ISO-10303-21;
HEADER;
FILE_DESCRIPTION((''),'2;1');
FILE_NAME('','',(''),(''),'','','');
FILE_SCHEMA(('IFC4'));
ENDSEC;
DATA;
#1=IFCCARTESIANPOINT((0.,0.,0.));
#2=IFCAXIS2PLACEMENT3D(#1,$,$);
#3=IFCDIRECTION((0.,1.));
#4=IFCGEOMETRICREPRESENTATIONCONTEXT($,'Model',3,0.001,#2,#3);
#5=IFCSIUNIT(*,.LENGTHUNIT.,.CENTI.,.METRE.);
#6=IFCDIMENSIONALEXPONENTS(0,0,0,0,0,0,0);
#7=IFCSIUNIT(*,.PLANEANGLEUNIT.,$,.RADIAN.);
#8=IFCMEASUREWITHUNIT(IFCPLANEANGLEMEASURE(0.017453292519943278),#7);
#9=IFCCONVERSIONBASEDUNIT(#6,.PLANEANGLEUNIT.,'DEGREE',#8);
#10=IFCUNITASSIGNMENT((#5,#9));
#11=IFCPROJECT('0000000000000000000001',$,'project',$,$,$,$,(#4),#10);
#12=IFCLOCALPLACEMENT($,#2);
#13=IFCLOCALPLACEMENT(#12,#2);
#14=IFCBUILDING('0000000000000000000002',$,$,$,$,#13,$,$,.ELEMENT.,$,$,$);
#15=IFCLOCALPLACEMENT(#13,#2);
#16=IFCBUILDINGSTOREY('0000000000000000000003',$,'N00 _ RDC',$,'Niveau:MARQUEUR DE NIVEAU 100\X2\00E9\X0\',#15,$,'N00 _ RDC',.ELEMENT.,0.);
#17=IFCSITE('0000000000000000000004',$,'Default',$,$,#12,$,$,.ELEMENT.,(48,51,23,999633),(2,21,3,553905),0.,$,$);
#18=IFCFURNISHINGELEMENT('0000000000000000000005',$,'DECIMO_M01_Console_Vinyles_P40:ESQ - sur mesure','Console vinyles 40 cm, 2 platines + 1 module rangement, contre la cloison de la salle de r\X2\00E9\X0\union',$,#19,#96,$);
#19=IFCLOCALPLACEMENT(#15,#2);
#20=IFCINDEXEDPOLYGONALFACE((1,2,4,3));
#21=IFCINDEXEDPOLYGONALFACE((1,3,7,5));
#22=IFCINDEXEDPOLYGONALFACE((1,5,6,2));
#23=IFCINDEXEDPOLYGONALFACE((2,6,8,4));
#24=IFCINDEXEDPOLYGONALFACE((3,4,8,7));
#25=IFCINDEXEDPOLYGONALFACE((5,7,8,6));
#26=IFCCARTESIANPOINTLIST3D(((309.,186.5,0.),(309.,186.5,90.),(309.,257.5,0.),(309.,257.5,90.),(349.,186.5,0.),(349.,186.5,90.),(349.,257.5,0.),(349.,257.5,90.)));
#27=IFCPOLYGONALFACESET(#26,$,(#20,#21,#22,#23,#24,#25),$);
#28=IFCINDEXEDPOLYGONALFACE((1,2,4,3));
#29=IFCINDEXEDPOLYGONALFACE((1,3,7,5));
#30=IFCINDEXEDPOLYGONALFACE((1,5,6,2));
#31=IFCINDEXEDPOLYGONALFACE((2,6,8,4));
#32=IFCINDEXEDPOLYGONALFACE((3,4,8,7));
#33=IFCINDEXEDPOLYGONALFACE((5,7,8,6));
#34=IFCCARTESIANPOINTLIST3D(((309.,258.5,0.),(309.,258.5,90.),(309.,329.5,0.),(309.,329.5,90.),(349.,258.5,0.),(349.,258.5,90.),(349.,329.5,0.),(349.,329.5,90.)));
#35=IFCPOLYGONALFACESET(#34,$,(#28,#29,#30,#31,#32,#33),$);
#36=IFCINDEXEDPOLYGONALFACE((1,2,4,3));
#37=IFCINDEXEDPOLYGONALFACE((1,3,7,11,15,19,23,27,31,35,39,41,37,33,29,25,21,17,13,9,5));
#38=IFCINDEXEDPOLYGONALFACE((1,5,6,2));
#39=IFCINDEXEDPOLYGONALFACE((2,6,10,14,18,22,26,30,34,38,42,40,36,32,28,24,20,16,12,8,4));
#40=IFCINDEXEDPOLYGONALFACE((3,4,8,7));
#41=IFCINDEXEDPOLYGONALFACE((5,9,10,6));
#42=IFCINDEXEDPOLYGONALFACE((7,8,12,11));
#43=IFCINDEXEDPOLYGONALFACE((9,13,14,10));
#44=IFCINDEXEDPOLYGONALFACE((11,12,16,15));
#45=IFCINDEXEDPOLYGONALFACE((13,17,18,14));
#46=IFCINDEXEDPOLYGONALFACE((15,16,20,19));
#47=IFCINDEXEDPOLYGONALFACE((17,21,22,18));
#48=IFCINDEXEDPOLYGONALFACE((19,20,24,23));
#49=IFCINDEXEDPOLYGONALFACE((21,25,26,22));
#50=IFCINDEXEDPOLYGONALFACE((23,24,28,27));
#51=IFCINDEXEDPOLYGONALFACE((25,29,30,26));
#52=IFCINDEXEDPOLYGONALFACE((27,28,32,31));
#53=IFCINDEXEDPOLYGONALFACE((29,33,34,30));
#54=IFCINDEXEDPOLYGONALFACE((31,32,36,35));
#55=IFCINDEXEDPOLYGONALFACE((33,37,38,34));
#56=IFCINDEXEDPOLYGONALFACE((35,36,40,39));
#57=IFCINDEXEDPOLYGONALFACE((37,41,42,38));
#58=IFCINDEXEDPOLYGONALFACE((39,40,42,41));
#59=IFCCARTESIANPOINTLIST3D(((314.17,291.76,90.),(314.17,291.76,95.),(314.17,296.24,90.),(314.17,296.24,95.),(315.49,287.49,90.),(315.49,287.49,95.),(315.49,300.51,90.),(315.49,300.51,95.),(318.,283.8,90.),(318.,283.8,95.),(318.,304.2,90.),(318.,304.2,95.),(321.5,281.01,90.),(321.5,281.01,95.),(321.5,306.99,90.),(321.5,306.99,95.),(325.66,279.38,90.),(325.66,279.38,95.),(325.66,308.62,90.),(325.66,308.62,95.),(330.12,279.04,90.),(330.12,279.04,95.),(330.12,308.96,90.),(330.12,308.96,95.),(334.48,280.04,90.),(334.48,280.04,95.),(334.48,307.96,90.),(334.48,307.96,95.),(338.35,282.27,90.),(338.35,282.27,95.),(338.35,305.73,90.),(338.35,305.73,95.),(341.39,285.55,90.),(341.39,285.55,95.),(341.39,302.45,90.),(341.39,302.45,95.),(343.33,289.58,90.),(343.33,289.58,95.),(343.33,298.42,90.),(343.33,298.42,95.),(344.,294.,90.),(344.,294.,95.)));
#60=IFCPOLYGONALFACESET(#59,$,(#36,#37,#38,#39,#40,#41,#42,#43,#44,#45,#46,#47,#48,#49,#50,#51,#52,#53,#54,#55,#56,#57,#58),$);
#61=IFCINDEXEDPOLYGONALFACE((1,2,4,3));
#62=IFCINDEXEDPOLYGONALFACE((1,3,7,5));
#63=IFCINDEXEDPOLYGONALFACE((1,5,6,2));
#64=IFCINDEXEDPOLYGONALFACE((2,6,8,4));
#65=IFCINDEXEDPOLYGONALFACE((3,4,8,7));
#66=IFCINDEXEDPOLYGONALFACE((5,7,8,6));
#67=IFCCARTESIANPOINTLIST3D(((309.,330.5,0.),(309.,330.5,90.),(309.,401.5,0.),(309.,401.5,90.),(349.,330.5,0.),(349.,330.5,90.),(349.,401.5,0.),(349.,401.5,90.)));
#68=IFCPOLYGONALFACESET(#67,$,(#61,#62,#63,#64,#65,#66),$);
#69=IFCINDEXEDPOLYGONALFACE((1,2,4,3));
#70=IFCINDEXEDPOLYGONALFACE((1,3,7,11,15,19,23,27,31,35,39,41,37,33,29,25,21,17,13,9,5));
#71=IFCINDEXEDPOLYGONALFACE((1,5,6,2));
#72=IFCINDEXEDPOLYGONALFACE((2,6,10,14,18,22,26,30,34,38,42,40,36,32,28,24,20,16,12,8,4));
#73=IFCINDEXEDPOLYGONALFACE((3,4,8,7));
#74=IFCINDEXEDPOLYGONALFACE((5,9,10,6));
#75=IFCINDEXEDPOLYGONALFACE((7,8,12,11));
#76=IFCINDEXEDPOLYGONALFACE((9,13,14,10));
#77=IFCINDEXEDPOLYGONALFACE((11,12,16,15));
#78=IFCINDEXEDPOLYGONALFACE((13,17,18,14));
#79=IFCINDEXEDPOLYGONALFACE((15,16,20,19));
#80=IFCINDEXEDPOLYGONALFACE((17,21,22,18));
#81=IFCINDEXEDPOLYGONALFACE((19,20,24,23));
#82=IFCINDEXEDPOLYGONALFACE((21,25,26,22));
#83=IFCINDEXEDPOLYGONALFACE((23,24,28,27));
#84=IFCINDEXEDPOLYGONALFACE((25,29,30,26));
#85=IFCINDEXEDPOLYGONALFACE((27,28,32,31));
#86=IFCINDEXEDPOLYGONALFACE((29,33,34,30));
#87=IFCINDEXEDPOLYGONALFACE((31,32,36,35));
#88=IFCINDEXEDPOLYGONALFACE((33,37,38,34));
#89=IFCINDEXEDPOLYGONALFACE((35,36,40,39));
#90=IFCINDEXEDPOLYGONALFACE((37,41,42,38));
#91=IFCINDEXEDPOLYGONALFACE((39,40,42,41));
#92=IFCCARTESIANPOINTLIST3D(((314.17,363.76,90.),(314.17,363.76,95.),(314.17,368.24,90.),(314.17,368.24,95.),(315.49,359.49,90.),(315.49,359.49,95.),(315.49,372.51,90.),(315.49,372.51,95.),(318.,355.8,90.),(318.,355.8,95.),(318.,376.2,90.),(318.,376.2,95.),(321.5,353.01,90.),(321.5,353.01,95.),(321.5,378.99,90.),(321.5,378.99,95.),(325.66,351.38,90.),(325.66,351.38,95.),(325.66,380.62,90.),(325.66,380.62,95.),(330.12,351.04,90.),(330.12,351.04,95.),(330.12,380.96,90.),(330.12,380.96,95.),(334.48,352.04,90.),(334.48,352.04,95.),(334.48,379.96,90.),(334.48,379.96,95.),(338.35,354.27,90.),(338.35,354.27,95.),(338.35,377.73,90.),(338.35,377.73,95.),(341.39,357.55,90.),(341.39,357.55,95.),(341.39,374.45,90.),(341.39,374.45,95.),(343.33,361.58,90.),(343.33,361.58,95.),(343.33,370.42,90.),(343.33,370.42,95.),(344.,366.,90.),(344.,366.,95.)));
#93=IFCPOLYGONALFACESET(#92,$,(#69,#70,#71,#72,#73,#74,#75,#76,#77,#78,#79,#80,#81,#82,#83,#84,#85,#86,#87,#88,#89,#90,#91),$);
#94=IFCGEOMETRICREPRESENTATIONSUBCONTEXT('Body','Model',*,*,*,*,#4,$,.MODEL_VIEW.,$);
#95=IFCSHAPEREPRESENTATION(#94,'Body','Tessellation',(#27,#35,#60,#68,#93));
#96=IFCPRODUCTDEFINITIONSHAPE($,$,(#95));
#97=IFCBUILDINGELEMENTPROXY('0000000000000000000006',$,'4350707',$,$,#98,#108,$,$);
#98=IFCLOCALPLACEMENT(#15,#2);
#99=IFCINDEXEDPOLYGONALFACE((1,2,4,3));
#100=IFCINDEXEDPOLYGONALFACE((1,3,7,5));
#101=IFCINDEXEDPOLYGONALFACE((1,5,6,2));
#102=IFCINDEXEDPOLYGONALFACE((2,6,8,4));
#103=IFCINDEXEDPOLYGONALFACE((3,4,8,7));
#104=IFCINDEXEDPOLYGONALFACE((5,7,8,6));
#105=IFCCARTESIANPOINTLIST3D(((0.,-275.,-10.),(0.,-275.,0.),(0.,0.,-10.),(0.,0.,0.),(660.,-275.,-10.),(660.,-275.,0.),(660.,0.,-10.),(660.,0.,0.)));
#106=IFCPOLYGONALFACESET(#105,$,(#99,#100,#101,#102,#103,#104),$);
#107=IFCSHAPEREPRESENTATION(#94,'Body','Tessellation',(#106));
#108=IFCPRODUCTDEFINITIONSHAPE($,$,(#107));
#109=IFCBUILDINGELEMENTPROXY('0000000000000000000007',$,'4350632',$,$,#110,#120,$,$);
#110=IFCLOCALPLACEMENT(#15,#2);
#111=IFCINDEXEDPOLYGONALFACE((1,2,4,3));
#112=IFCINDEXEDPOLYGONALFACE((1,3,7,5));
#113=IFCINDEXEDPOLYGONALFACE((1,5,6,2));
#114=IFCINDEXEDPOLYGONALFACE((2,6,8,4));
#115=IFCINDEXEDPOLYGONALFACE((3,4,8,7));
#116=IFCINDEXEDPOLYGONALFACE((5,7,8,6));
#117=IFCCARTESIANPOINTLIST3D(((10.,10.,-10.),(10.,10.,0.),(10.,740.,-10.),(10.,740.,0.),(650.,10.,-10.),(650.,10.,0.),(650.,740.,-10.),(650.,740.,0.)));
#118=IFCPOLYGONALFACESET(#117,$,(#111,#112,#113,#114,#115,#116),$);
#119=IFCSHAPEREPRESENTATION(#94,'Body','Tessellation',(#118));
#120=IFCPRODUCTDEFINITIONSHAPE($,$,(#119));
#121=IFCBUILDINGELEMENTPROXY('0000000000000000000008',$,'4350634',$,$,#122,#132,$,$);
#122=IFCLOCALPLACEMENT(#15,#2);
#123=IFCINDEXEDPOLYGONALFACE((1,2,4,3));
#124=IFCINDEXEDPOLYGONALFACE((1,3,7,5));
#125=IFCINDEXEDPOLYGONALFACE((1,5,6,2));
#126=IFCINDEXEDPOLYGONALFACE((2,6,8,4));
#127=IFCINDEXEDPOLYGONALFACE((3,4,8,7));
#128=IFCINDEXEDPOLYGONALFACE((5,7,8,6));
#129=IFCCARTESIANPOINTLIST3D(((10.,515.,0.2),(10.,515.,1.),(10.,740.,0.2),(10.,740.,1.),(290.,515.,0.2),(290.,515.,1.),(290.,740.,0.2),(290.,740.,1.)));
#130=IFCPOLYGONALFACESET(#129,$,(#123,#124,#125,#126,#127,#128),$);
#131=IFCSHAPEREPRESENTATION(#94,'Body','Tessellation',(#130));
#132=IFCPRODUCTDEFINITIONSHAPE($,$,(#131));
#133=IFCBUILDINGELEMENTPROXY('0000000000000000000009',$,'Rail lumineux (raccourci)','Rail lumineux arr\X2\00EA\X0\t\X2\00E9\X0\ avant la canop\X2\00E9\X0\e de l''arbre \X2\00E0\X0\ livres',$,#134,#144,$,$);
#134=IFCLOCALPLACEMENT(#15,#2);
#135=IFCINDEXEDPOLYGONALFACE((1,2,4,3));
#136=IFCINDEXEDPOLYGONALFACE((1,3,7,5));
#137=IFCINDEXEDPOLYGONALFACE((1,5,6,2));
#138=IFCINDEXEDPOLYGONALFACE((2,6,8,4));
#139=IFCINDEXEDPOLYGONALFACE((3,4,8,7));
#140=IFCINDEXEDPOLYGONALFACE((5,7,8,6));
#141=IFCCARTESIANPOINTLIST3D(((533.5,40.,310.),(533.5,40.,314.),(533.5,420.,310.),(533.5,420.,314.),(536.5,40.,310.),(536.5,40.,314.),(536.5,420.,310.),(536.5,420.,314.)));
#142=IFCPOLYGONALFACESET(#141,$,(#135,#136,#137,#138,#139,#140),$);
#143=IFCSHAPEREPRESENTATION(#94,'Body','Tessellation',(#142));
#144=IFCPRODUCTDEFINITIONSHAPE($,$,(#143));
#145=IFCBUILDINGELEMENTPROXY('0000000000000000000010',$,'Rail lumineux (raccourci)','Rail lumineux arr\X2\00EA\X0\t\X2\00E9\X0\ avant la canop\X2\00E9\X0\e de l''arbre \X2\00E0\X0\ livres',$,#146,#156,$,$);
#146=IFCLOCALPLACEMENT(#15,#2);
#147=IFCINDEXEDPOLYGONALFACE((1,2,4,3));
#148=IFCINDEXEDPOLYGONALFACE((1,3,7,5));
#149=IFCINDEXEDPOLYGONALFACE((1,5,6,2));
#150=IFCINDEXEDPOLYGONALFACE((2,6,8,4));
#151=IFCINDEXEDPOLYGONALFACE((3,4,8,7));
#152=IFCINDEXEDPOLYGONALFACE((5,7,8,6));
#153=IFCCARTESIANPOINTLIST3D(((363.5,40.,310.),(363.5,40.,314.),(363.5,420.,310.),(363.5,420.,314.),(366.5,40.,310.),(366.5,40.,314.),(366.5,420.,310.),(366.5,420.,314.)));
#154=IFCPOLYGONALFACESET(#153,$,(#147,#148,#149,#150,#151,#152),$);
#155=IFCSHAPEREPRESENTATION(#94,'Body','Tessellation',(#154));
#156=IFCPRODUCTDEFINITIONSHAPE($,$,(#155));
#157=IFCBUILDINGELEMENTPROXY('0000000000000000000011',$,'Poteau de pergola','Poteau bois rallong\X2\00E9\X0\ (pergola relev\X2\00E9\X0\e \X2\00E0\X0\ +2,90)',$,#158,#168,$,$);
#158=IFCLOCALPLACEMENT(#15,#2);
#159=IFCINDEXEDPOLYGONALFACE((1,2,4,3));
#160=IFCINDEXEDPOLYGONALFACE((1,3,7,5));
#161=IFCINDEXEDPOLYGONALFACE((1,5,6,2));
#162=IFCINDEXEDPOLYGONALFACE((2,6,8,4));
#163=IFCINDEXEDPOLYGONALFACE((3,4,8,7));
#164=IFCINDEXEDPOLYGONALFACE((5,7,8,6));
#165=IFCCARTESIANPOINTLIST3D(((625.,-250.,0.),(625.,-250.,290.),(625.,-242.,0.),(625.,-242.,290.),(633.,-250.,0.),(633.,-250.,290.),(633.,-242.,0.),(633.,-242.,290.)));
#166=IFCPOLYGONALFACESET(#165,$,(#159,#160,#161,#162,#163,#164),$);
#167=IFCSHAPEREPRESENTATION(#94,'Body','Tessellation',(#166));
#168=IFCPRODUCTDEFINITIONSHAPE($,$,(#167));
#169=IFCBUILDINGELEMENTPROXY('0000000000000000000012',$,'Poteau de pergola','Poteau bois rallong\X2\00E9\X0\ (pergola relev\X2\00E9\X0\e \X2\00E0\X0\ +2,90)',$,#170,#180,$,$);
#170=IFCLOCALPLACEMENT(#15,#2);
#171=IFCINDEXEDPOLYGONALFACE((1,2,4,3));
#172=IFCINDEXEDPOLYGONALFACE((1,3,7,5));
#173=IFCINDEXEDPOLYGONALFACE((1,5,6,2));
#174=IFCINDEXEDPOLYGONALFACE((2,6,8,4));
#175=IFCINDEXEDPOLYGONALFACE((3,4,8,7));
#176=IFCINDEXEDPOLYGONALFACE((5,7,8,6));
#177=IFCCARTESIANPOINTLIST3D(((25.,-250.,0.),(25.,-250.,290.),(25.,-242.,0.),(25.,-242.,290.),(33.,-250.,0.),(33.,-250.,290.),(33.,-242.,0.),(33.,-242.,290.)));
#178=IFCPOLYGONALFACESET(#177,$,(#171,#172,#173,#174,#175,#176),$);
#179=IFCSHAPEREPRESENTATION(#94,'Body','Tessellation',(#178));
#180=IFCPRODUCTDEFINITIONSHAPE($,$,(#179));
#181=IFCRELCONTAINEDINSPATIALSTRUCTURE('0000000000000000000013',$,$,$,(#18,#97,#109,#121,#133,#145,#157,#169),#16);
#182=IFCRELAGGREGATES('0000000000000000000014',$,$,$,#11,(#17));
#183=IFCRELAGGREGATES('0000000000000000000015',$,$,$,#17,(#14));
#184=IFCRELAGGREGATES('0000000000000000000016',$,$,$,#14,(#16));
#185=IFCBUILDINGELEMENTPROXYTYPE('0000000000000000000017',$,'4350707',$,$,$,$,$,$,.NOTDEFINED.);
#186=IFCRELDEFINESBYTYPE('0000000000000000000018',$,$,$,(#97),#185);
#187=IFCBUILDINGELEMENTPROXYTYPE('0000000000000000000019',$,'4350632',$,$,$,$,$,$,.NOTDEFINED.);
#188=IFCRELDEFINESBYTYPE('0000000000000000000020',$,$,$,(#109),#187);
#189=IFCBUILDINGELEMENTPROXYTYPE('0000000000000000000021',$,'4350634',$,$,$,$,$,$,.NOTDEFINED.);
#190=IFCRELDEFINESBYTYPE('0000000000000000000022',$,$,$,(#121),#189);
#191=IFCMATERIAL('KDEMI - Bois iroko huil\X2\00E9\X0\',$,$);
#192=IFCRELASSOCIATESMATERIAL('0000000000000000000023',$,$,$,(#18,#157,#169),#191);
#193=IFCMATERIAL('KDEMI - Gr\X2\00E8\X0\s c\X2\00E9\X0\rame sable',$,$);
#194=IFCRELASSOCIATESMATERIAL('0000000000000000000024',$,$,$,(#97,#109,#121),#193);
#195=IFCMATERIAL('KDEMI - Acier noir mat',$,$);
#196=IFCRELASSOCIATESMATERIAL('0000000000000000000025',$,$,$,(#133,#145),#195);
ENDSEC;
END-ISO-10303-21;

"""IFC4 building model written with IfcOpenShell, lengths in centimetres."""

from ifc_helpers import new_model, entity, si_unit, converted_unit, direction, frame, frame_2d, origin, origin_with_axes, origin_2d_with_axis, place, context, subcontext, project, spatial, rectangle, circle, extrude, material, type_object, element, save


model = new_model("IFC4")

# Units and contexts
model_context = context("Model", 3, precision=0.001, world=origin(), true_north=direction((0.0, 1.0)))
body_context = subcontext(model_context, "Body", "Model", "MODEL_VIEW")
ifc_project = project(units=[si_unit("LENGTHUNIT", "METRE", prefix="CENTI"), converted_unit("PLANEANGLEUNIT", "DEGREE", entity("IfcPlaneAngleMeasure", 0.017453292519943278), si_unit("PLANEANGLEUNIT", "RADIAN"), dimensions=[0, 0, 0, 0, 0, 0, 0])], contexts=[model_context])

# Site, building, storey
site_placement = place(None, origin())
site = spatial("IfcSite", under=ifc_project, at=site_placement, Name="Default", CompositionType="ELEMENT", RefLatitude=(48, 51, 23, 999633), RefLongitude=(2, 21, 3, 553905), RefElevation=0.0)
building_placement = place(site_placement, origin())
building = spatial("IfcBuilding", under=site, at=building_placement, CompositionType="ELEMENT")
storey_placement = place(building_placement, origin())
storey = spatial("IfcBuildingStorey", under=building, at=storey_placement, Name="N00 _ RDC", ObjectType="Niveau:MARQUEUR DE NIVEAU 100é", LongName="N00 _ RDC", CompositionType="ELEMENT", Elevation=0.0)

# Shared definitions
ifc_material_1 = material(Name="KDEMI - Acier noir mat")

# Furnishing element
ifc_material_2 = material(Name="KDEMI - Bois iroko huilé")
furnishing_1_placement = place(storey_placement, origin_with_axes())
element("IfcFurnishingElement", 1, at=furnishing_1_placement, inside=storey, material=ifc_material_2, Name="DECIMO_M01_Console_Vinyles_P40:ESQ - sur mesure", Description="Console vinyles 40 cm, 2 platines + 1 module rangement, contre la cloison de la salle de réunion", context=body_context, shape_type="SweptSolid", body=[
    extrude(rectangle(XDim=40.0, YDim=71.0, at=frame_2d((329.0, 222.0))), origin(), (0.0, 0.0, 1.0), 90.0),
    extrude(rectangle(XDim=40.0, YDim=71.0, at=frame_2d((329.0, 294.0))), origin(), (0.0, 0.0, 1.0), 90.0),
    extrude(circle(Radius=15.0, at=frame_2d((329.0, 294.0))), frame((0.0, 0.0, 90.0)), (0.0, 0.0, 1.0), 5.0),
    extrude(rectangle(XDim=40.0, YDim=71.0, at=frame_2d((329.0, 366.0))), origin(), (0.0, 0.0, 1.0), 90.0),
    extrude(circle(Radius=15.0, at=frame_2d((329.0, 366.0))), frame((0.0, 0.0, 90.0)), (0.0, 0.0, 1.0), 5.0),
])

# Building element proxies
ifc_material_3 = material(Name="KDEMI - Grès cérame sable")
building_element_proxy_type_1 = type_object("IfcBuildingElementProxyType", Name="4350707", PredefinedType="NOTDEFINED")
proxy_1_placement = place(storey_placement, origin())
element("IfcBuildingElementProxy", 2, at=proxy_1_placement, inside=storey, type_object=building_element_proxy_type_1, material=ifc_material_3, Name="4350707", context=body_context, shape_type="SweptSolid", body=[
    extrude(rectangle(XDim=660.0, YDim=275.0, at=origin_2d_with_axis()), frame((330.0, -137.5, -10.0)), (0.0, 0.0, 1.0), 10.0),
])
building_element_proxy_type_2 = type_object("IfcBuildingElementProxyType", Name="4350632", PredefinedType="NOTDEFINED")
proxy_2_placement = place(storey_placement, origin())
element("IfcBuildingElementProxy", 3, at=proxy_2_placement, inside=storey, type_object=building_element_proxy_type_2, material=ifc_material_3, Name="4350632", context=body_context, shape_type="SweptSolid", body=[
    extrude(rectangle(XDim=640.0, YDim=730.0, at=origin_2d_with_axis()), frame((330.0, 375.0, -10.0)), (0.0, 0.0, 1.0), 10.0),
])
building_element_proxy_type_3 = type_object("IfcBuildingElementProxyType", Name="4350634", PredefinedType="NOTDEFINED")
proxy_3_placement = place(storey_placement, origin())
element("IfcBuildingElementProxy", 4, at=proxy_3_placement, inside=storey, type_object=building_element_proxy_type_3, material=ifc_material_3, Name="4350634", context=body_context, shape_type="SweptSolid", body=[
    extrude(rectangle(XDim=280.0, YDim=225.0, at=frame_2d((0.0, 0.0), x_axis=(1.0, 0.0))), frame((150.0, 627.5, 0.2)), (0.0, 0.0, 1.0), 0.8),
])
proxy_4_placement = place(storey_placement, origin_with_axes())
element("IfcBuildingElementProxy", 5, at=proxy_4_placement, inside=storey, material=ifc_material_1, Name="Rail lumineux (raccourci)", Description="Rail lumineux arrêté avant la canopée de l'arbre à livres", context=body_context, shape_type="SweptSolid", body=[
    extrude(rectangle(XDim=3.0, YDim=380.0, at=frame_2d((535.0, 230.0))), frame((0.0, 0.0, 310.0)), (0.0, 0.0, 1.0), 4.0),
])
proxy_5_placement = place(storey_placement, origin_with_axes())
element("IfcBuildingElementProxy", 6, at=proxy_5_placement, inside=storey, material=ifc_material_1, Name="Rail lumineux (raccourci)", Description="Rail lumineux arrêté avant la canopée de l'arbre à livres", context=body_context, shape_type="SweptSolid", body=[
    extrude(rectangle(XDim=3.0, YDim=380.0, at=frame_2d((365.0, 230.0))), frame((0.0, 0.0, 310.0)), (0.0, 0.0, 1.0), 4.0),
])
proxy_6_placement = place(storey_placement, origin_with_axes())
element("IfcBuildingElementProxy", 7, at=proxy_6_placement, inside=storey, material=ifc_material_2, Name="Poteau de pergola", Description="Poteau bois rallongé (pergola relevée à +2,90)", context=body_context, shape_type="SweptSolid", body=[
    extrude(rectangle(XDim=8.0, YDim=8.0, at=frame_2d((629.0, -246.0))), origin(), (0.0, 0.0, 1.0), 290.0),
])
proxy_7_placement = place(storey_placement, origin_with_axes())
element("IfcBuildingElementProxy", 8, at=proxy_7_placement, inside=storey, material=ifc_material_2, Name="Poteau de pergola", Description="Poteau bois rallongé (pergola relevée à +2,90)", context=body_context, shape_type="SweptSolid", body=[
    extrude(rectangle(XDim=8.0, YDim=8.0, at=frame_2d((29.0, -246.0))), origin(), (0.0, 0.0, 1.0), 290.0),
])

save(model, "model.ifc")
